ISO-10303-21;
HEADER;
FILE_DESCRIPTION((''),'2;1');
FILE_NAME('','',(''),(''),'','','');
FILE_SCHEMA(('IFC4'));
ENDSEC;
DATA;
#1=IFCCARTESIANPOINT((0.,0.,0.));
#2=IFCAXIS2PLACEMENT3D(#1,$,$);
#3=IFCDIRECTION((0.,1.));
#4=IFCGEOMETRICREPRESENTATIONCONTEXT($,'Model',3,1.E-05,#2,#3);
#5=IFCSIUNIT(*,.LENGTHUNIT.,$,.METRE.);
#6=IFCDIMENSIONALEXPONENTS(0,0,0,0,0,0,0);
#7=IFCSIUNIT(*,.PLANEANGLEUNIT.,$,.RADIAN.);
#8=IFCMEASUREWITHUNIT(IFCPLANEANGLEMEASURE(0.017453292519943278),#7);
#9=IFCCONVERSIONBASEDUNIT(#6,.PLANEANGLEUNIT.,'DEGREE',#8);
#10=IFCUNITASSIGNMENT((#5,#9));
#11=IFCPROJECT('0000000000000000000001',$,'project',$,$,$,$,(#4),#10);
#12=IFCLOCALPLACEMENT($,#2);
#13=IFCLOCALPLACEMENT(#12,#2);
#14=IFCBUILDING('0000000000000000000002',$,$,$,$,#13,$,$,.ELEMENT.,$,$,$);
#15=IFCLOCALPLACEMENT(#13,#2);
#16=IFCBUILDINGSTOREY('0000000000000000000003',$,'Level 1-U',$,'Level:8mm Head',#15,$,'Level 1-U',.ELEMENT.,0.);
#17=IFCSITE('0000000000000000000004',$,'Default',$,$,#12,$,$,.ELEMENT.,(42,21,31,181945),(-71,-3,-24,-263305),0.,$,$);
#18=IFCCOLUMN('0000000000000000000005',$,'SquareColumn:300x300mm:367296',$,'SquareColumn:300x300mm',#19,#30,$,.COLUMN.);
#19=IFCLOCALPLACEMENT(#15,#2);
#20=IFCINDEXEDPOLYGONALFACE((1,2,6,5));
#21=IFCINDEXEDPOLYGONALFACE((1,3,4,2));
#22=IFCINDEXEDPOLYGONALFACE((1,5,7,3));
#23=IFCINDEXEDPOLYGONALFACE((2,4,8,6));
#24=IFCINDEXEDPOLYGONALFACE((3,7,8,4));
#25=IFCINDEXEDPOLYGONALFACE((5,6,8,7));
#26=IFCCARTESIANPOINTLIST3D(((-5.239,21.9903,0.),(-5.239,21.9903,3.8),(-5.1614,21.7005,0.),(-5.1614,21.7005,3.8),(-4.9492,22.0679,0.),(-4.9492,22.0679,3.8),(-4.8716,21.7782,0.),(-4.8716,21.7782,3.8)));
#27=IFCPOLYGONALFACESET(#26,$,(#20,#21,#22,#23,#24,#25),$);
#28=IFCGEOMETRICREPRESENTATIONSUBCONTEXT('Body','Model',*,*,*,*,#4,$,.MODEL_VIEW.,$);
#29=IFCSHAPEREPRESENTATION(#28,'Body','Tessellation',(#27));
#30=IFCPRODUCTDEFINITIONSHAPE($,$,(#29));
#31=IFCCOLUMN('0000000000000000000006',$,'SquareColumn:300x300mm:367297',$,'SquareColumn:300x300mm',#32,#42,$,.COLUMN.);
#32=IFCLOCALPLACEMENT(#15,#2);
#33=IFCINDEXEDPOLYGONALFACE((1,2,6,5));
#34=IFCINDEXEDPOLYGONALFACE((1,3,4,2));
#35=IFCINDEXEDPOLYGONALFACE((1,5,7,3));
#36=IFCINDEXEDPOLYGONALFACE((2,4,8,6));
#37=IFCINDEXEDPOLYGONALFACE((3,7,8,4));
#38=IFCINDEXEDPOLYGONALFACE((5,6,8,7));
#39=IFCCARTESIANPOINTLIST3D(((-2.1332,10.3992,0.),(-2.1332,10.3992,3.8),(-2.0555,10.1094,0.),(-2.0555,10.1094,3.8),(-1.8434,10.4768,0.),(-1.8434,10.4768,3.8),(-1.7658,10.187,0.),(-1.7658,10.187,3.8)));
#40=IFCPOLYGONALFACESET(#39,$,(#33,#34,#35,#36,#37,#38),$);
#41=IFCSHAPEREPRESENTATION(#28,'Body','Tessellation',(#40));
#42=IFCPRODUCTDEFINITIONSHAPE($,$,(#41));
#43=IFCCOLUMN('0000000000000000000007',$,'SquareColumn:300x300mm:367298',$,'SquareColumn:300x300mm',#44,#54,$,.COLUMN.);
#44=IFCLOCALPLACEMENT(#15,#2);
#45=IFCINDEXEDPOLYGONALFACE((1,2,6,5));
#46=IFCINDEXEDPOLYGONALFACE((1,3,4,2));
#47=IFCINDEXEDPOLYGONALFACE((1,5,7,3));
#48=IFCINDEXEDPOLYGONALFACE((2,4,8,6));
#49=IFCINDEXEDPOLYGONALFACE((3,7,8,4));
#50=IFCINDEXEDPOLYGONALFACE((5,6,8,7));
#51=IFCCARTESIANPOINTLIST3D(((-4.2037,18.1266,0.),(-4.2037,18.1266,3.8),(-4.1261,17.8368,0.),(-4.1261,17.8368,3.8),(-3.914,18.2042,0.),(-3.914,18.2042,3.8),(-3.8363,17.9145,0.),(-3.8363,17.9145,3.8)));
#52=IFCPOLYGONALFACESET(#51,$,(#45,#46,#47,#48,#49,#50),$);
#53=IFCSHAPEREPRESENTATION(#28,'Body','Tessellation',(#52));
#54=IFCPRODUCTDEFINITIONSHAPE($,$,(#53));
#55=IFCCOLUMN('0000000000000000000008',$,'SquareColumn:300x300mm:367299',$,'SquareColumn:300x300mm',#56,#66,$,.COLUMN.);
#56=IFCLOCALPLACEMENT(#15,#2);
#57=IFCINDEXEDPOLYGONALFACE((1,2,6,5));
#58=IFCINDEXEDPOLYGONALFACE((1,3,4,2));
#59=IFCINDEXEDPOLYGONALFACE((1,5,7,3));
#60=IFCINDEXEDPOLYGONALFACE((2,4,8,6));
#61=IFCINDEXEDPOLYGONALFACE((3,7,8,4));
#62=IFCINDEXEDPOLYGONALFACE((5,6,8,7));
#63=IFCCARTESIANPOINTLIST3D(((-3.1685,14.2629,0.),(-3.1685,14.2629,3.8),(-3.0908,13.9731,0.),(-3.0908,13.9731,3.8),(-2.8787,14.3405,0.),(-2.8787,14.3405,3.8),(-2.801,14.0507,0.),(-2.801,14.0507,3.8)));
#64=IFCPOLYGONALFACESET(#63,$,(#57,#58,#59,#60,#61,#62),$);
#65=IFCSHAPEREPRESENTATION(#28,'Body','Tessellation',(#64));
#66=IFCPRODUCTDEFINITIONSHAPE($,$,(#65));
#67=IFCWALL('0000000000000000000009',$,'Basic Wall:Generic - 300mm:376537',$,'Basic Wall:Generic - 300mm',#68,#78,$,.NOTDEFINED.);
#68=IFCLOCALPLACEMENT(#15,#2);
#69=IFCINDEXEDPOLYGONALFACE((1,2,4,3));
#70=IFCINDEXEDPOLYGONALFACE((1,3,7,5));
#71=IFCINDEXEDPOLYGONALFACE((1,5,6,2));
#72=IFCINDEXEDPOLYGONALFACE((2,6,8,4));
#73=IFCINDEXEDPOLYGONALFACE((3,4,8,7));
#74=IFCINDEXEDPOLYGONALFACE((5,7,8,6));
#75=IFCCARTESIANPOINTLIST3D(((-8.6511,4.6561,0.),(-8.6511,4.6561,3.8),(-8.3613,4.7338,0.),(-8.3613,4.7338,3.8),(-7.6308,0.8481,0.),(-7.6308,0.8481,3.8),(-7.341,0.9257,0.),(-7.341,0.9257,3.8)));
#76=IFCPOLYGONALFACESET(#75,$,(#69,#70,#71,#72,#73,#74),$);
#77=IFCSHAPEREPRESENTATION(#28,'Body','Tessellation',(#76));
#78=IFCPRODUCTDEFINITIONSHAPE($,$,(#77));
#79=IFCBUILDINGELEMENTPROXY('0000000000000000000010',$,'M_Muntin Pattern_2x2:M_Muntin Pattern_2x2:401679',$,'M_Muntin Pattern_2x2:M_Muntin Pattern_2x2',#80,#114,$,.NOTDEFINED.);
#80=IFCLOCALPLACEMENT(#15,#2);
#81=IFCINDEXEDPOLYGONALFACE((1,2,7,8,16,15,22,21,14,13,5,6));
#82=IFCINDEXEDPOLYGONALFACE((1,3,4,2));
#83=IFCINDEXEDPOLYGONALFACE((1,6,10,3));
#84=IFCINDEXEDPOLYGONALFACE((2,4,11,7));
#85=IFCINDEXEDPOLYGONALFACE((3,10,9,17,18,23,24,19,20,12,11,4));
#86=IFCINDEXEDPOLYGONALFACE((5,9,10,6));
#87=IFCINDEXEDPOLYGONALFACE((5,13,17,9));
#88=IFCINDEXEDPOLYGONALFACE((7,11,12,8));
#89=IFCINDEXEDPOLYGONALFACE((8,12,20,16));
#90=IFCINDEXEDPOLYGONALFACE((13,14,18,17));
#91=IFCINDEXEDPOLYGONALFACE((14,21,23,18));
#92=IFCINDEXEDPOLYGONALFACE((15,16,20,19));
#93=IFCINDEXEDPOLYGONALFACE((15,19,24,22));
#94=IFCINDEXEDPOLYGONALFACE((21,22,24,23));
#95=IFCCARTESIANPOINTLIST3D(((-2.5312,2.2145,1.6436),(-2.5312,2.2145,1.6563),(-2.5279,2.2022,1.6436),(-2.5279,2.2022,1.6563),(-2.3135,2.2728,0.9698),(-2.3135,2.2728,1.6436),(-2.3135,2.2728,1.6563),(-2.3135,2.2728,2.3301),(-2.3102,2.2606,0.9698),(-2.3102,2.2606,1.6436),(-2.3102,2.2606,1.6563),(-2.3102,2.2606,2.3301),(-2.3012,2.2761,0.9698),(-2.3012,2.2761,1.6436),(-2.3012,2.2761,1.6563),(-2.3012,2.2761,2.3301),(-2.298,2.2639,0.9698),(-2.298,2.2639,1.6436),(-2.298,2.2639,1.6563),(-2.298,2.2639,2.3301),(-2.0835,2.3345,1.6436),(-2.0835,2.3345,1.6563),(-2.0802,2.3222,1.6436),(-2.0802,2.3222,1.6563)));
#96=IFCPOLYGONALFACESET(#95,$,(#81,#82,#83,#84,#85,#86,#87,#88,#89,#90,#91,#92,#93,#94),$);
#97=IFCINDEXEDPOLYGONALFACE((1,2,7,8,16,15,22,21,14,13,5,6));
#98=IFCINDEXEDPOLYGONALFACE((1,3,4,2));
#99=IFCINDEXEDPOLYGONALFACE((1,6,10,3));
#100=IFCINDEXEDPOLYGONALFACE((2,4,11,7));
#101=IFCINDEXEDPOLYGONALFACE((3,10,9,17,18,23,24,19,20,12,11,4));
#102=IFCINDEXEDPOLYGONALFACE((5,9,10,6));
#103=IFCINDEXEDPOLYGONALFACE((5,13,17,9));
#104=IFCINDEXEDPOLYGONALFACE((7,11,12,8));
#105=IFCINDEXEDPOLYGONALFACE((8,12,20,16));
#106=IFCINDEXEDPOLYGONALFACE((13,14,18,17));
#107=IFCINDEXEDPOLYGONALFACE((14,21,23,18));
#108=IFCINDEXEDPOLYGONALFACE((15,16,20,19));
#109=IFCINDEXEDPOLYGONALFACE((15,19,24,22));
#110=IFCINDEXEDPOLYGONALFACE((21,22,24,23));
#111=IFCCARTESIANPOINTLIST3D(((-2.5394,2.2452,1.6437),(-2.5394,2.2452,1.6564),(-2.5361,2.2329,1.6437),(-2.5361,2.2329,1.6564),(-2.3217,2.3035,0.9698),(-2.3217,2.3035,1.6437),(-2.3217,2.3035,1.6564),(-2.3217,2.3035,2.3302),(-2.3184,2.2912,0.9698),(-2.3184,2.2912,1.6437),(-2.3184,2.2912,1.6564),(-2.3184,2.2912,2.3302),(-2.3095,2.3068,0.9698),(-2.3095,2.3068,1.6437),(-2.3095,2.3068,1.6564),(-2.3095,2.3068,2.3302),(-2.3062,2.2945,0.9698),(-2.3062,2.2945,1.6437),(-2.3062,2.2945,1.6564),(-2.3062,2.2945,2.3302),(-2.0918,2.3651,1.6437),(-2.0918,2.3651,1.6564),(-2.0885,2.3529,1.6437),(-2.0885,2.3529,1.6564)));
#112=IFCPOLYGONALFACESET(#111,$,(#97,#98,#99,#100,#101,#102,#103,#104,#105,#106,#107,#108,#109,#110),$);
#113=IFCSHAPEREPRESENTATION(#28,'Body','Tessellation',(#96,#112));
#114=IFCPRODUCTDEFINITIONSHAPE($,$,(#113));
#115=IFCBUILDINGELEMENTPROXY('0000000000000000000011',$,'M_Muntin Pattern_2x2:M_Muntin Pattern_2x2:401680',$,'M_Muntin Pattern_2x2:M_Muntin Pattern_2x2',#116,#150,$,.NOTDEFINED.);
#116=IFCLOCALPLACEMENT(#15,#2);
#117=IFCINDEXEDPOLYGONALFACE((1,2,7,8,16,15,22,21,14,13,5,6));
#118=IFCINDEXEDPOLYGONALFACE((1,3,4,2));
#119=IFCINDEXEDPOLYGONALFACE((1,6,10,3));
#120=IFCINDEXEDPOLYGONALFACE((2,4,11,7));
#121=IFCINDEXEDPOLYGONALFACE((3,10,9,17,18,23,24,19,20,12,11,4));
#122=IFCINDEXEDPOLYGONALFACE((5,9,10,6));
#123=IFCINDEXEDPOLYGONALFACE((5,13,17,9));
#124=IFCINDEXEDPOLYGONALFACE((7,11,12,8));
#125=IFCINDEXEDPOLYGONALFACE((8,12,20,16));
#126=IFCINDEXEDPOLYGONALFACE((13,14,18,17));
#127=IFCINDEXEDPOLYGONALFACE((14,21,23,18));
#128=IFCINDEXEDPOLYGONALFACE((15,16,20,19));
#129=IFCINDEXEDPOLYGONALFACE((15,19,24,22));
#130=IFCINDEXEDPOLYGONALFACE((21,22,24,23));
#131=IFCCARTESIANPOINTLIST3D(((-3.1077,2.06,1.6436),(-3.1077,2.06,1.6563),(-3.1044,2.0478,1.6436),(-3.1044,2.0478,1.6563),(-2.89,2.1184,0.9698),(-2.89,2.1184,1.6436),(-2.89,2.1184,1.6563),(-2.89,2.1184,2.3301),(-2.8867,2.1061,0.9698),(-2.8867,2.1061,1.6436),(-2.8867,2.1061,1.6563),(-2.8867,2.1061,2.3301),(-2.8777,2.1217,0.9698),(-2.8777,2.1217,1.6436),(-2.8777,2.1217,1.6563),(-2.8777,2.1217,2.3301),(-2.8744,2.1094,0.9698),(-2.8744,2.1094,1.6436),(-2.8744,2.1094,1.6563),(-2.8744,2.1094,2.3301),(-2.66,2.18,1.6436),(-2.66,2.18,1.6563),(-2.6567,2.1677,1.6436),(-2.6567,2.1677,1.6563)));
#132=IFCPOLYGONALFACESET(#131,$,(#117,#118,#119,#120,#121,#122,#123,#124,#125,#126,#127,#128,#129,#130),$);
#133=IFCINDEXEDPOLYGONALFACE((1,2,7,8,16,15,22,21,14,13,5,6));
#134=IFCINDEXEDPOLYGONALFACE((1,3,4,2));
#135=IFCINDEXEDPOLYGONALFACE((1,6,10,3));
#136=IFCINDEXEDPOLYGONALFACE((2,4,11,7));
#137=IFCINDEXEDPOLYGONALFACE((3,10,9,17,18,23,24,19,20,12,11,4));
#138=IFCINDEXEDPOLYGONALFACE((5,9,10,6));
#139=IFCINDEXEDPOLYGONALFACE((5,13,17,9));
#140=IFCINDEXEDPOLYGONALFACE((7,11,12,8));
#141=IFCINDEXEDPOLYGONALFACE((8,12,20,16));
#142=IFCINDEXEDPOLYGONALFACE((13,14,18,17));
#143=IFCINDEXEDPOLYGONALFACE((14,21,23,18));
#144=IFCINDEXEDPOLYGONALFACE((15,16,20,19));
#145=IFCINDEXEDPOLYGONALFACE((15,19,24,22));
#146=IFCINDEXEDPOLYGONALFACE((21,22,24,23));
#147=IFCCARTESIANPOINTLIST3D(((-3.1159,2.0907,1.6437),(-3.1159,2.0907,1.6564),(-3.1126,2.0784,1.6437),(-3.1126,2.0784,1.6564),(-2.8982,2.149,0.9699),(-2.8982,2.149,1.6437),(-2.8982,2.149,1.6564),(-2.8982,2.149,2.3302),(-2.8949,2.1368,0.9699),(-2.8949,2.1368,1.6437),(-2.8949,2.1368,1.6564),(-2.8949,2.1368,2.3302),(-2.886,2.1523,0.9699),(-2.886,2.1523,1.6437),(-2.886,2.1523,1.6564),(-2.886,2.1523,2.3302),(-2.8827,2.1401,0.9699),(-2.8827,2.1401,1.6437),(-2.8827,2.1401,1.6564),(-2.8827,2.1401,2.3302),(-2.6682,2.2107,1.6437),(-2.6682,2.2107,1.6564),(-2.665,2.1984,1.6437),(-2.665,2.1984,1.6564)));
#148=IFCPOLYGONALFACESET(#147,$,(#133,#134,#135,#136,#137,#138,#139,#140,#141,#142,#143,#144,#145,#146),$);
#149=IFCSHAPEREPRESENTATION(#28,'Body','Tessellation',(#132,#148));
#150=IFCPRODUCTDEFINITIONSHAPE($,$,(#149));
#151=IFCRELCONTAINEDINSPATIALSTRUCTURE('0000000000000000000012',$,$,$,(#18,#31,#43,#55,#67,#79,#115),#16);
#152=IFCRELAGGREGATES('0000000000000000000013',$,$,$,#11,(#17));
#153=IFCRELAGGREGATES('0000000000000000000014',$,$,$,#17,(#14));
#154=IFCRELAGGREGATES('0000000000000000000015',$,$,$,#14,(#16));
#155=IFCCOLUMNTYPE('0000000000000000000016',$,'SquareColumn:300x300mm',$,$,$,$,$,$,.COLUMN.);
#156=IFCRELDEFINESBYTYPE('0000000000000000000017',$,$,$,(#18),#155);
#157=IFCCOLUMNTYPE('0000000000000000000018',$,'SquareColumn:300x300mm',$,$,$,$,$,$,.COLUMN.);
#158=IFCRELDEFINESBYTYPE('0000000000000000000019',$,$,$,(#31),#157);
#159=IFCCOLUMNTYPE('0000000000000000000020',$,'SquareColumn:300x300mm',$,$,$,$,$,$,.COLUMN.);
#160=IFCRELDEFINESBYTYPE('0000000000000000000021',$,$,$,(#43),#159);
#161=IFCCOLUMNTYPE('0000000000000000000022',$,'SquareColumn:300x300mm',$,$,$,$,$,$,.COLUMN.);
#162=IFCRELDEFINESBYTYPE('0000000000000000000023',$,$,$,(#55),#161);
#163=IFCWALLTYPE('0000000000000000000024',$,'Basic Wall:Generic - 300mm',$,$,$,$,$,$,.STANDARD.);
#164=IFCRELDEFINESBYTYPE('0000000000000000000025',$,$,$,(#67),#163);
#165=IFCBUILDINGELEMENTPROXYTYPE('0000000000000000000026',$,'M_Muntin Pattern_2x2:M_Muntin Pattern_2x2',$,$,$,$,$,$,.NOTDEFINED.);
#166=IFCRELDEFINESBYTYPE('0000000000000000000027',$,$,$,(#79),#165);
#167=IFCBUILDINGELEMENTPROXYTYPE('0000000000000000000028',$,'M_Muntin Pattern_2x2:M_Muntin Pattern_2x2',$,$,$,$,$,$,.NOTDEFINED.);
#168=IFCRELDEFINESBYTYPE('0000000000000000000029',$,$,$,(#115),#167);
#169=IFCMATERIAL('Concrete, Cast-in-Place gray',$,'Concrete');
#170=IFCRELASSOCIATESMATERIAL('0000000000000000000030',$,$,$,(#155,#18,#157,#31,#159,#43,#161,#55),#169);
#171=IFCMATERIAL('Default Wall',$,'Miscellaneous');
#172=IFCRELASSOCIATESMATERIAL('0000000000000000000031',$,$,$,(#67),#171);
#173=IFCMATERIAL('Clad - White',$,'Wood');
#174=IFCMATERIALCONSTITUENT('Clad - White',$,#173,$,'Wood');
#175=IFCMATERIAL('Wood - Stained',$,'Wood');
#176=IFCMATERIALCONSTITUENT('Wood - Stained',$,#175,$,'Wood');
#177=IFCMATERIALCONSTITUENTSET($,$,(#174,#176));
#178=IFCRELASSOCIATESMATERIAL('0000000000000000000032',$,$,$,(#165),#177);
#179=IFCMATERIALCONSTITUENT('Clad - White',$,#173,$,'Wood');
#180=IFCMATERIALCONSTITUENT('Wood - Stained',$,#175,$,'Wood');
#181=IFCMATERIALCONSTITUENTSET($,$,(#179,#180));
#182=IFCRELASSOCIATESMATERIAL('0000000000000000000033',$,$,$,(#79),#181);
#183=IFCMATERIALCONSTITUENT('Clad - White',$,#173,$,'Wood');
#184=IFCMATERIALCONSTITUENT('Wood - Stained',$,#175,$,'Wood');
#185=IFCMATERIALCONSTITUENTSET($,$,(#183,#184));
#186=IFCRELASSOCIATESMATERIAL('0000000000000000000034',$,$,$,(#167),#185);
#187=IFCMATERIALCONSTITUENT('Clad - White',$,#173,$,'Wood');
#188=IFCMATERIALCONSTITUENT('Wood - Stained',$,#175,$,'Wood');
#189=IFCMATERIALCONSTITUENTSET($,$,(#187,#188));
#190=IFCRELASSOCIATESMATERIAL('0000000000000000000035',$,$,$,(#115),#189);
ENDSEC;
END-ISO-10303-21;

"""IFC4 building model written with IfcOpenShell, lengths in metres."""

from ifc_helpers import new_model, entity, si_unit, converted_unit, direction, frame, origin, place, context, subcontext, project, spatial, indexed_curve, outline, extrude, source, transform, mapped, material, constituent, constituent_set, type_object, type_shapes, element, save


model = new_model("IFC4")

# Units and contexts
model_context = context("Model", 3, precision=1e-05, world=origin(), true_north=direction((0.0, 1.0)))
body_context = subcontext(model_context, "Body", "Model", "MODEL_VIEW")
ifc_project = project(units=[si_unit("LENGTHUNIT", "METRE"), converted_unit("PLANEANGLEUNIT", "DEGREE", entity("IfcPlaneAngleMeasure", 0.017453292519943278), si_unit("PLANEANGLEUNIT", "RADIAN"), dimensions=[0, 0, 0, 0, 0, 0, 0])], contexts=[model_context])

# Site, building, storey
site_placement = place(None, origin())
site = spatial("IfcSite", under=ifc_project, at=site_placement, Name="Default", CompositionType="ELEMENT", RefLatitude=(42, 21, 31, 181945), RefLongitude=(-71, -3, -24, -263305), RefElevation=0.0)
building_placement = place(site_placement, origin())
building = spatial("IfcBuilding", under=site, at=building_placement, CompositionType="ELEMENT")
storey_placement = place(building_placement, origin())
storey = spatial("IfcBuildingStorey", under=building, at=storey_placement, Name="Level 1-U", ObjectType="Level:8mm Head", LongName="Level 1-U", CompositionType="ELEMENT", Elevation=0.0)

# Columns
ifc_material_1 = material(Name="Concrete, Cast-in-Place gray", Category="Concrete")
column_type_1 = type_object("IfcColumnType", Name="SquareColumn:300x300mm", PredefinedType="COLUMN", material=ifc_material_1)
shared_shape_1 = source(origin(), body_context, "Body", "SweptSolid", [
    extrude(outline(indexed_curve([(-0.15, -0.15), (0.15, -0.15), (0.15, 0.15), (-0.15, 0.15), (-0.15, -0.15)], self_intersect=False)), frame((-5.0553, 21.8842, 0.0), z_axis=(0.0, 0.0, 1.0), x_axis=(-0.258819, 0.965926, 0.0)), (0.0, 0.0, 1.0), 3.8),
])
type_shapes(column_type_1, [shared_shape_1])
column_1_placement = place(storey_placement, origin())
element("IfcColumn", 1, at=column_1_placement, inside=storey, type_object=column_type_1, material=ifc_material_1, Name="SquareColumn:300x300mm:367296", ObjectType="SquareColumn:300x300mm", PredefinedType="COLUMN", context=body_context, shape_type="MappedRepresentation", body=[
    mapped(shared_shape_1, transform((0.0, 0.0, 0.0), scale=1.0)),
])
column_type_2 = type_object("IfcColumnType", Name="SquareColumn:300x300mm", PredefinedType="COLUMN", material=ifc_material_1)
shared_shape_2 = source(origin(), body_context, "Body", "SweptSolid", [
    extrude(outline(indexed_curve([(-0.15, -0.15), (0.15, -0.15), (0.15, 0.15), (-0.15, 0.15), (-0.15, -0.15)], self_intersect=False)), frame((-1.9495, 10.2931, 0.0), z_axis=(0.0, 0.0, 1.0), x_axis=(-0.258819, 0.965926, 0.0)), (0.0, 0.0, 1.0), 3.8),
])
type_shapes(column_type_2, [shared_shape_2])
column_2_placement = place(storey_placement, origin())
element("IfcColumn", 2, at=column_2_placement, inside=storey, type_object=column_type_2, material=ifc_material_1, Name="SquareColumn:300x300mm:367297", ObjectType="SquareColumn:300x300mm", PredefinedType="COLUMN", context=body_context, shape_type="MappedRepresentation", body=[
    mapped(shared_shape_2, transform((0.0, 0.0, 0.0), scale=1.0)),
])
column_type_3 = type_object("IfcColumnType", Name="SquareColumn:300x300mm", PredefinedType="COLUMN", material=ifc_material_1)
shared_shape_3 = source(origin(), body_context, "Body", "SweptSolid", [
    extrude(outline(indexed_curve([(-0.15, -0.15), (0.15, -0.15), (0.15, 0.15), (-0.15, 0.15), (-0.15, -0.15)], self_intersect=False)), frame((-4.02, 18.0205, 0.0), z_axis=(0.0, 0.0, 1.0), x_axis=(-0.258819, 0.965926, 0.0)), (0.0, 0.0, 1.0), 3.8),
])
type_shapes(column_type_3, [shared_shape_3])
column_3_placement = place(storey_placement, origin())
element("IfcColumn", 3, at=column_3_placement, inside=storey, type_object=column_type_3, material=ifc_material_1, Name="SquareColumn:300x300mm:367298", ObjectType="SquareColumn:300x300mm", PredefinedType="COLUMN", context=body_context, shape_type="MappedRepresentation", body=[
    mapped(shared_shape_3, transform((0.0, 0.0, 0.0), scale=1.0)),
])
column_type_4 = type_object("IfcColumnType", Name="SquareColumn:300x300mm", PredefinedType="COLUMN", material=ifc_material_1)
shared_shape_4 = source(origin(), body_context, "Body", "SweptSolid", [
    extrude(outline(indexed_curve([(-0.15, -0.15), (0.15, -0.15), (0.15, 0.15), (-0.15, 0.15), (-0.15, -0.15)], self_intersect=False)), frame((-2.9847, 14.1568, 0.0), z_axis=(0.0, 0.0, 1.0), x_axis=(-0.258819, 0.965926, 0.0)), (0.0, 0.0, 1.0), 3.8),
])
type_shapes(column_type_4, [shared_shape_4])
column_4_placement = place(storey_placement, origin())
element("IfcColumn", 4, at=column_4_placement, inside=storey, type_object=column_type_4, material=ifc_material_1, Name="SquareColumn:300x300mm:367299", ObjectType="SquareColumn:300x300mm", PredefinedType="COLUMN", context=body_context, shape_type="MappedRepresentation", body=[
    mapped(shared_shape_4, transform((0.0, 0.0, 0.0), scale=1.0)),
])

# Wall
ifc_material_2 = material(Name="Default Wall", Category="Miscellaneous")
wall_type = type_object("IfcWallType", Name="Basic Wall:Generic - 300mm", PredefinedType="STANDARD")
wall_placement = place(storey_placement, frame((-8.5062, 4.6949, 0.0), z_axis=(0.0, 0.0, 1.0), x_axis=(0.258819, -0.965926, 0.0)))
element("IfcWall", 5, at=wall_placement, inside=storey, type_object=wall_type, material=ifc_material_2, Name="Basic Wall:Generic - 300mm:376537", ObjectType="Basic Wall:Generic - 300mm", PredefinedType="NOTDEFINED", context=body_context, shape_type="SweptSolid", body=[
    extrude(outline(indexed_curve([(3.9424, 0.15), (0.0, 0.15), (0.0, -0.15), (3.9424, -0.15), (3.9424, 0.15)], self_intersect=False)), origin(), (0.0, 0.0, 1.0), 3.8),
])

# Building element proxies
ifc_material_3 = material(Name="Clad - White", Category="Wood")
ifc_constituent_1 = constituent(ifc_material_3, Name="Clad - White", Category="Wood")
ifc_material_4 = material(Name="Wood - Stained", Category="Wood")
ifc_constituent_2 = constituent(ifc_material_4, Name="Wood - Stained", Category="Wood")
ifc_constituent_set_1 = constituent_set(constituents=[ifc_constituent_1, ifc_constituent_2])
ifc_constituent_3 = constituent(ifc_material_3, Name="Clad - White", Category="Wood")
ifc_constituent_4 = constituent(ifc_material_4, Name="Wood - Stained", Category="Wood")
ifc_constituent_set_2 = constituent_set(constituents=[ifc_constituent_3, ifc_constituent_4])
building_element_proxy_type_1 = type_object("IfcBuildingElementProxyType", Name="M_Muntin Pattern_2x2:M_Muntin Pattern_2x2", PredefinedType="NOTDEFINED", material=ifc_constituent_set_2)
shared_shape_5 = source(origin(), body_context, "Body", "SweptSolid", [
    extrude(outline(indexed_curve([(0.0064, -0.0064), (0.6801, -0.0064), (0.6801, 0.0063), (0.0064, 0.0063), (0.0064, 0.2317), (-0.0063, 0.2317), (-0.0063, 0.0063), (-0.6802, 0.0063), (-0.6802, -0.0064), (-0.0063, -0.0064), (-0.0063, -0.2317), (0.0064, -0.2317), (0.0064, -0.0064)], self_intersect=False)), frame((0.0, 0.0095, 0.6801), z_axis=(0.0, 1.0, 0.0), x_axis=(0.0, 0.0, 1.0)), (0.0, 0.0, 1.0), 0.0127),
    extrude(outline(indexed_curve([(0.0064, -0.0064), (0.6802, -0.0064), (0.6802, 0.0063), (0.0064, 0.0063), (0.0064, 0.2317), (-0.0063, 0.2317), (-0.0063, 0.0063), (-0.6802, 0.0063), (-0.6802, -0.0064), (-0.0063, -0.0064), (-0.0063, -0.2317), (0.0064, -0.2317), (0.0064, -0.0064)], self_intersect=False)), frame((0.0, -0.0222, 0.6802), z_axis=(0.0, 1.0, 0.0), x_axis=(0.0, 0.0, 1.0)), (0.0, 0.0, 1.0), 0.0127),
])
type_shapes(building_element_proxy_type_1, [shared_shape_5])
proxy_1_placement = place(storey_placement, frame((-2.3098, 2.2837, 0.9698), z_axis=(0.0, 0.0, 1.0), x_axis=(-0.965926, -0.258819, 0.0)))
element("IfcBuildingElementProxy", 6, at=proxy_1_placement, inside=storey, type_object=building_element_proxy_type_1, material=ifc_constituent_set_1, Name="M_Muntin Pattern_2x2:M_Muntin Pattern_2x2:401679", ObjectType="M_Muntin Pattern_2x2:M_Muntin Pattern_2x2", PredefinedType="NOTDEFINED", context=body_context, shape_type="MappedRepresentation", body=[
    mapped(shared_shape_5, transform((0.0, 0.0, 0.0), scale=1.0)),
])
ifc_constituent_5 = constituent(ifc_material_3, Name="Clad - White", Category="Wood")
ifc_constituent_6 = constituent(ifc_material_4, Name="Wood - Stained", Category="Wood")
ifc_constituent_set_3 = constituent_set(constituents=[ifc_constituent_5, ifc_constituent_6])
ifc_constituent_7 = constituent(ifc_material_3, Name="Clad - White", Category="Wood")
ifc_constituent_8 = constituent(ifc_material_4, Name="Wood - Stained", Category="Wood")
ifc_constituent_set_4 = constituent_set(constituents=[ifc_constituent_7, ifc_constituent_8])
building_element_proxy_type_2 = type_object("IfcBuildingElementProxyType", Name="M_Muntin Pattern_2x2:M_Muntin Pattern_2x2", PredefinedType="NOTDEFINED", material=ifc_constituent_set_4)
shared_shape_6 = source(origin(), body_context, "Body", "SweptSolid", [
    extrude(outline(indexed_curve([(0.0064, -0.0064), (0.6801, -0.0064), (0.6801, 0.0063), (0.0064, 0.0063), (0.0064, 0.2317), (-0.0063, 0.2317), (-0.0063, 0.0063), (-0.6802, 0.0063), (-0.6802, -0.0064), (-0.0063, -0.0064), (-0.0063, -0.2317), (0.0064, -0.2317), (0.0064, -0.0064)], self_intersect=False)), frame((0.0, -0.0222, 0.6801), z_axis=(0.0, 1.0, 0.0), x_axis=(0.0, 0.0, 1.0)), (0.0, 0.0, 1.0), 0.0127),
    extrude(outline(indexed_curve([(0.0064, -0.0064), (0.6802, -0.0064), (0.6802, 0.0063), (0.0064, 0.0063), (0.0064, 0.2317), (-0.0063, 0.2317), (-0.0063, 0.0063), (-0.6802, 0.0063), (-0.6802, -0.0064), (-0.0063, -0.0064), (-0.0063, -0.2317), (0.0064, -0.2317), (0.0064, -0.0064)], self_intersect=False)), frame((0.0, 0.0095, 0.6802), z_axis=(0.0, 1.0, 0.0), x_axis=(0.0, 0.0, 1.0)), (0.0, 0.0, 1.0), 0.0127),
])
type_shapes(building_element_proxy_type_2, [shared_shape_6])
proxy_2_placement = place(storey_placement, frame((-2.8863, 2.1292, 0.9699), z_axis=(0.0, 0.0, 1.0), x_axis=(0.965926, 0.258819, 0.0)))
element("IfcBuildingElementProxy", 7, at=proxy_2_placement, inside=storey, type_object=building_element_proxy_type_2, material=ifc_constituent_set_3, Name="M_Muntin Pattern_2x2:M_Muntin Pattern_2x2:401680", ObjectType="M_Muntin Pattern_2x2:M_Muntin Pattern_2x2", PredefinedType="NOTDEFINED", context=body_context, shape_type="MappedRepresentation", body=[
    mapped(shared_shape_6, transform((0.0, 0.0, 0.0), scale=1.0)),
])

save(model, "model.ifc")
